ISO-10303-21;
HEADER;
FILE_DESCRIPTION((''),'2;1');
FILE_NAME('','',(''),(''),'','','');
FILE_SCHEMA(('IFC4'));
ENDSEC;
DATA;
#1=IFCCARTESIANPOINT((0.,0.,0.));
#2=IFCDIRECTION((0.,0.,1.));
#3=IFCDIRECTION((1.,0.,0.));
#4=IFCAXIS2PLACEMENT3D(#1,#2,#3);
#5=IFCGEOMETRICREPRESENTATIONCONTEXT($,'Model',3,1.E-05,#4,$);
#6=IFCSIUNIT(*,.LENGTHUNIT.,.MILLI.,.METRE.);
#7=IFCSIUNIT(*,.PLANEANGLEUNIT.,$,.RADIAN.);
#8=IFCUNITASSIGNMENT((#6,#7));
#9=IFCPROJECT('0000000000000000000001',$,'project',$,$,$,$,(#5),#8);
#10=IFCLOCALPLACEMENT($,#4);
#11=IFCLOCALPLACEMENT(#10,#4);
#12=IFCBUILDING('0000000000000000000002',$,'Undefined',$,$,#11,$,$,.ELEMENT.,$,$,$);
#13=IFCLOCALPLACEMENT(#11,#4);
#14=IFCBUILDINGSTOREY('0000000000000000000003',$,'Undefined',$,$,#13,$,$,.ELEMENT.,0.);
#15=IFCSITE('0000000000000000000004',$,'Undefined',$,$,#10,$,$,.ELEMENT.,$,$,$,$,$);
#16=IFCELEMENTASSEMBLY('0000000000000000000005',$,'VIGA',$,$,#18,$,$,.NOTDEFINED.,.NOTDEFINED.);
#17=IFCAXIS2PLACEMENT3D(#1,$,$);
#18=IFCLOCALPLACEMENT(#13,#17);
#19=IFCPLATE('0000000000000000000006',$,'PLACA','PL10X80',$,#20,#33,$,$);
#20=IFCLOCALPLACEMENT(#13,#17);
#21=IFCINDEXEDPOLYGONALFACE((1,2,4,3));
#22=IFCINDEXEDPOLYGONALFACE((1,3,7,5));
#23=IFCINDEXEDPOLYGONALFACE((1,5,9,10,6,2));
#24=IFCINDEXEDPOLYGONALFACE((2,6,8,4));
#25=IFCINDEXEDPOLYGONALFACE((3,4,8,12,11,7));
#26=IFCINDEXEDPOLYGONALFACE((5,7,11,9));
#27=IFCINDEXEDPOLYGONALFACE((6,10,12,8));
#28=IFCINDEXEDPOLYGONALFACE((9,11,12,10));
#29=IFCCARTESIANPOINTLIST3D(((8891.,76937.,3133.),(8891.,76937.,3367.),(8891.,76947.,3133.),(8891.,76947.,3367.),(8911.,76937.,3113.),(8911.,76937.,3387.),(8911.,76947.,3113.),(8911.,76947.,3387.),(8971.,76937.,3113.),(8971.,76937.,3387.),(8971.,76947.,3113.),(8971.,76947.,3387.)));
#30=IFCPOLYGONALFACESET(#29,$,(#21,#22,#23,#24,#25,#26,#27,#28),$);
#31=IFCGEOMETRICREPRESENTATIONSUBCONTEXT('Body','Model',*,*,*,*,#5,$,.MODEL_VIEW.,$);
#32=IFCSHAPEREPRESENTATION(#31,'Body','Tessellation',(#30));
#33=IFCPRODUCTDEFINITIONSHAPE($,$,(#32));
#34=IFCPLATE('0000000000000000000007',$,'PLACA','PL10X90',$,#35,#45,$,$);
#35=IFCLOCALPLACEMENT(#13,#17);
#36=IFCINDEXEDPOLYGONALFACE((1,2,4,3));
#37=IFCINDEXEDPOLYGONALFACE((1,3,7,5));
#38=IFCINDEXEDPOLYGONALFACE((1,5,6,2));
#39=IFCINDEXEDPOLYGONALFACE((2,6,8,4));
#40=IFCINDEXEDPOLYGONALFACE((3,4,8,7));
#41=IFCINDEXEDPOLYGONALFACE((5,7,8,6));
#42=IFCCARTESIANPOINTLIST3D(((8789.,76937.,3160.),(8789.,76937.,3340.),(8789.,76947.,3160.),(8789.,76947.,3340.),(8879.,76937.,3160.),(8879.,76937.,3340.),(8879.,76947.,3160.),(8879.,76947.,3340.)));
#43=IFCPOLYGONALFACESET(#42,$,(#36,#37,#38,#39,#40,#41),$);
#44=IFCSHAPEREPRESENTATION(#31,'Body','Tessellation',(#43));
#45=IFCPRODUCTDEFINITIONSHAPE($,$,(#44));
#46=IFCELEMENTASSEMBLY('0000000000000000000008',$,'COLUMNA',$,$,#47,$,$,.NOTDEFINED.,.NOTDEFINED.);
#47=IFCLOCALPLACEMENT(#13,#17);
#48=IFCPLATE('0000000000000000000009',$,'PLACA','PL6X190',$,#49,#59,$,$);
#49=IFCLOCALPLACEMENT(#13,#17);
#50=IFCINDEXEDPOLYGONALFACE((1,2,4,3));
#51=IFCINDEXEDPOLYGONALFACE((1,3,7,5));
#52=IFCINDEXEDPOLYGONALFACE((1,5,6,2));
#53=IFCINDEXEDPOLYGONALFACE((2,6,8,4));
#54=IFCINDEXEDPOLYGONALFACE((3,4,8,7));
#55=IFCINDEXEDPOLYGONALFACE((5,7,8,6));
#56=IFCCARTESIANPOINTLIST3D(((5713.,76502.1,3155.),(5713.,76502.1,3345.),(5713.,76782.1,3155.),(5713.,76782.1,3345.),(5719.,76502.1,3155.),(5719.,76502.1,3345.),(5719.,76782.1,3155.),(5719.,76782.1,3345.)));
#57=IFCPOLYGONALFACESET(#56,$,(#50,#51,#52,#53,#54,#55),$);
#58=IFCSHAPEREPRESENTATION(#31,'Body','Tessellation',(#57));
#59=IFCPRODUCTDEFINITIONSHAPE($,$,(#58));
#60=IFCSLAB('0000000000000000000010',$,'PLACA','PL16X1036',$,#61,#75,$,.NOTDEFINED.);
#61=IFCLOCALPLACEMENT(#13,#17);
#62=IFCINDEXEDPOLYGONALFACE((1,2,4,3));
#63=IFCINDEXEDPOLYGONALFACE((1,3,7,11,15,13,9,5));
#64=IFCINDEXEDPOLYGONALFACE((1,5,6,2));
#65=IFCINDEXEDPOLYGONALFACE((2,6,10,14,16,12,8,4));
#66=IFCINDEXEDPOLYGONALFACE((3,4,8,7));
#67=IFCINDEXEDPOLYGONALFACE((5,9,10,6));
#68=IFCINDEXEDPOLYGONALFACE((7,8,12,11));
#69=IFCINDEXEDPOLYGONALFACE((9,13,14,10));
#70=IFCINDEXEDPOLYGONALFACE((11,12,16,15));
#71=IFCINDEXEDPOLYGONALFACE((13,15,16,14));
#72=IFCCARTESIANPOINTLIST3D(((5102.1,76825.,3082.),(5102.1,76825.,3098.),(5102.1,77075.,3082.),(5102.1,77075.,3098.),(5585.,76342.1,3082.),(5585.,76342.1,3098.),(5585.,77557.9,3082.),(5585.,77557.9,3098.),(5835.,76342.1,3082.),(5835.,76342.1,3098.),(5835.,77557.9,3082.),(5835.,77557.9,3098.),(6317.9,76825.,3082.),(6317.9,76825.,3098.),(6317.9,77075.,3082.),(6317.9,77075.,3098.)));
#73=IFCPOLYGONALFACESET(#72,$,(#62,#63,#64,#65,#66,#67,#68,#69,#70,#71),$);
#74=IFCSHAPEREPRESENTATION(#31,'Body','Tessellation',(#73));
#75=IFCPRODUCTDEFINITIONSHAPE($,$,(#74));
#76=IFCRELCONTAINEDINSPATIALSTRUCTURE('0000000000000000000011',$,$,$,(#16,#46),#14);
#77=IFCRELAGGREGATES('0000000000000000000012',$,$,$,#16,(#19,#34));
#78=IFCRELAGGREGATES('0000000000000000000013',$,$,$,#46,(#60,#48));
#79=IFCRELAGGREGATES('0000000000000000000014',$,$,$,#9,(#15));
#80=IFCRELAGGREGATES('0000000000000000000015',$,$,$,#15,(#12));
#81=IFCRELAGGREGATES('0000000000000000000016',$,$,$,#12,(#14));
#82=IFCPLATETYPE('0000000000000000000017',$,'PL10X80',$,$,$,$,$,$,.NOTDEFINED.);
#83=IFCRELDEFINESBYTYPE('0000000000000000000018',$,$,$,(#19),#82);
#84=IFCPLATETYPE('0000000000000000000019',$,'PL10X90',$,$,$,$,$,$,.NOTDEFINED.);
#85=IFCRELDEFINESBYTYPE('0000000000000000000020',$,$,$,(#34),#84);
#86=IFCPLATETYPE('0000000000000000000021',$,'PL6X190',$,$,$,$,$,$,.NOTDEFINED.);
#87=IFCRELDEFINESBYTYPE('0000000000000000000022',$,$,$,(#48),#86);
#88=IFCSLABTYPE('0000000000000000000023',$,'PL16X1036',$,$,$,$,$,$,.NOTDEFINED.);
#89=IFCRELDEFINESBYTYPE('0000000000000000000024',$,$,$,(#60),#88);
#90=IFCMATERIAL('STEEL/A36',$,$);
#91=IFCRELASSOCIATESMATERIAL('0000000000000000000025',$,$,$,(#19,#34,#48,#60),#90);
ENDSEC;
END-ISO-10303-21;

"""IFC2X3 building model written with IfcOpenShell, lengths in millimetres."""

from ifc_helpers import new_model, si_unit, frame, origin_with_axes, place, context, subcontext, project, spatial, polyline, outline, extrude, material, type_object, element, aggregate, save


model = new_model("IFC2X3")

# Units and contexts
model_context = context("Model", 3, precision=1e-05, world=origin_with_axes())
body_context = subcontext(model_context, "Body", "Model", "MODEL_VIEW")
ifc_project = project(units=[si_unit("LENGTHUNIT", "METRE", prefix="MILLI"), si_unit("PLANEANGLEUNIT", "RADIAN")], contexts=[model_context])

# Site, building, storey
site_placement = place(None, origin_with_axes())
site = spatial("IfcSite", under=ifc_project, at=site_placement, Name="Undefined", CompositionType="ELEMENT")
building_placement = place(site_placement, origin_with_axes())
building = spatial("IfcBuilding", under=site, at=building_placement, Name="Undefined", CompositionType="ELEMENT")
storey_placement = place(building_placement, origin_with_axes())
storey = spatial("IfcBuildingStorey", under=building, at=storey_placement, Name="Undefined", CompositionType="ELEMENT", Elevation=0.0)

# Shared definitions
ifc_material_1 = material(Name="STEEL/A36")

# Element assembly, plates
assembly_1_placement = place(storey_placement, origin_with_axes())
assembly_1 = element("IfcElementAssembly", 1, at=assembly_1_placement, inside=storey, Name="VIGA", AssemblyPlace="NOTDEFINED", PredefinedType="NOTDEFINED")
plate_type_1 = type_object("IfcPlateType", Name="PL10X80", PredefinedType="NOTDEFINED")
plate_1_placement = place(assembly_1_placement, frame((8891.0, 76942.0, 3113.0), z_axis=(0.0, -1.0, 0.0), x_axis=(1.0, 0.0, 0.0)))
plate_1 = element("IfcPlate", 2, at=plate_1_placement, type_object=plate_type_1, material=ifc_material_1, Name="PLACA", Description="PL10X80", context=body_context, shape_type="SweptSolid", body=[
    extrude(outline(polyline([(0.0, 20.0), (20.0, 0.0), (80.0, 0.0), (80.0, 274.0), (20.0, 274.0), (0.0, 254.0), (0.0, 20.0)])), frame((0.0, 0.0, -5.0), z_axis=(0.0, 0.0, 1.0), x_axis=(1.0, 0.0, 0.0)), (0.0, 0.0, 1.0), 10.0),
])
plate_type_2 = type_object("IfcPlateType", Name="PL10X90", PredefinedType="NOTDEFINED")
plate_2_placement = place(assembly_1_placement, frame((8879.0, 76942.0, 3340.0), z_axis=(0.0, 1.0, 0.0), x_axis=(0.0, 0.0, -1.0)))
plate_2 = element("IfcPlate", 3, at=plate_2_placement, type_object=plate_type_2, material=ifc_material_1, Name="PLACA", Description="PL10X90", context=body_context, shape_type="SweptSolid", body=[
    extrude(outline(polyline([(0.0, 0.0), (180.0, 0.0), (180.0, 90.0), (0.0, 90.0), (0.0, 0.0)])), frame((0.0, 0.0, -5.0), z_axis=(0.0, 0.0, 1.0), x_axis=(1.0, 0.0, 0.0)), (0.0, 0.0, 1.0), 10.0),
])
aggregate(assembly_1, [plate_1, plate_2])

# Element assembly, plate, slab
assembly_2_placement = place(storey_placement, origin_with_axes())
assembly_2 = element("IfcElementAssembly", 4, at=assembly_2_placement, inside=storey, Name="COLUMNA", AssemblyPlace="NOTDEFINED", PredefinedType="NOTDEFINED")
plate_type_3 = type_object("IfcPlateType", Name="PL6X190", PredefinedType="NOTDEFINED")
plate_3_placement = place(assembly_2_placement, frame((5716.0, 76502.1, 3250.0), z_axis=(1.0, 0.0, 0.0), x_axis=(0.0, 1.0, 0.0)))
plate_3 = element("IfcPlate", 5, at=plate_3_placement, type_object=plate_type_3, material=ifc_material_1, Name="PLACA", Description="PL6X190", context=body_context, shape_type="SweptSolid", body=[
    extrude(outline(polyline([(0.0, -95.0), (0.0, 95.0), (280.0, 95.0), (280.0, -95.0), (0.0, -95.0)])), frame((0.0, 0.0, -3.0), z_axis=(0.0, 0.0, 1.0), x_axis=(1.0, 0.0, 0.0)), (0.0, 0.0, 1.0), 6.0),
])
slab_type = type_object("IfcSlabType", Name="PL16X1036", PredefinedType="NOTDEFINED")
slab_placement = place(assembly_2_placement, frame((5835.0, 76342.1, 3090.0), z_axis=(0.0, 0.0, 1.0), x_axis=(0.707107, 0.707107, 0.0)))
slab = element("IfcSlab", 6, at=slab_placement, type_object=slab_type, material=ifc_material_1, Name="PLACA", Description="PL16X1036", PredefinedType="NOTDEFINED", context=body_context, shape_type="SweptSolid", body=[
    extrude(outline(polyline([(0.0, 0.0), (682.9, 0.0), (859.7, 176.8), (859.7, 859.7), (682.9, 1036.5), (0.0, 1036.5), (-176.8, 859.7), (-176.8, 176.8), (0.0, 0.0)])), frame((0.0, 0.0, -8.0), z_axis=(0.0, 0.0, 1.0), x_axis=(1.0, 0.0, 0.0)), (0.0, 0.0, 1.0), 16.0),
])

aggregate(assembly_2, [slab, plate_3])

save(model, "model.ifc")
